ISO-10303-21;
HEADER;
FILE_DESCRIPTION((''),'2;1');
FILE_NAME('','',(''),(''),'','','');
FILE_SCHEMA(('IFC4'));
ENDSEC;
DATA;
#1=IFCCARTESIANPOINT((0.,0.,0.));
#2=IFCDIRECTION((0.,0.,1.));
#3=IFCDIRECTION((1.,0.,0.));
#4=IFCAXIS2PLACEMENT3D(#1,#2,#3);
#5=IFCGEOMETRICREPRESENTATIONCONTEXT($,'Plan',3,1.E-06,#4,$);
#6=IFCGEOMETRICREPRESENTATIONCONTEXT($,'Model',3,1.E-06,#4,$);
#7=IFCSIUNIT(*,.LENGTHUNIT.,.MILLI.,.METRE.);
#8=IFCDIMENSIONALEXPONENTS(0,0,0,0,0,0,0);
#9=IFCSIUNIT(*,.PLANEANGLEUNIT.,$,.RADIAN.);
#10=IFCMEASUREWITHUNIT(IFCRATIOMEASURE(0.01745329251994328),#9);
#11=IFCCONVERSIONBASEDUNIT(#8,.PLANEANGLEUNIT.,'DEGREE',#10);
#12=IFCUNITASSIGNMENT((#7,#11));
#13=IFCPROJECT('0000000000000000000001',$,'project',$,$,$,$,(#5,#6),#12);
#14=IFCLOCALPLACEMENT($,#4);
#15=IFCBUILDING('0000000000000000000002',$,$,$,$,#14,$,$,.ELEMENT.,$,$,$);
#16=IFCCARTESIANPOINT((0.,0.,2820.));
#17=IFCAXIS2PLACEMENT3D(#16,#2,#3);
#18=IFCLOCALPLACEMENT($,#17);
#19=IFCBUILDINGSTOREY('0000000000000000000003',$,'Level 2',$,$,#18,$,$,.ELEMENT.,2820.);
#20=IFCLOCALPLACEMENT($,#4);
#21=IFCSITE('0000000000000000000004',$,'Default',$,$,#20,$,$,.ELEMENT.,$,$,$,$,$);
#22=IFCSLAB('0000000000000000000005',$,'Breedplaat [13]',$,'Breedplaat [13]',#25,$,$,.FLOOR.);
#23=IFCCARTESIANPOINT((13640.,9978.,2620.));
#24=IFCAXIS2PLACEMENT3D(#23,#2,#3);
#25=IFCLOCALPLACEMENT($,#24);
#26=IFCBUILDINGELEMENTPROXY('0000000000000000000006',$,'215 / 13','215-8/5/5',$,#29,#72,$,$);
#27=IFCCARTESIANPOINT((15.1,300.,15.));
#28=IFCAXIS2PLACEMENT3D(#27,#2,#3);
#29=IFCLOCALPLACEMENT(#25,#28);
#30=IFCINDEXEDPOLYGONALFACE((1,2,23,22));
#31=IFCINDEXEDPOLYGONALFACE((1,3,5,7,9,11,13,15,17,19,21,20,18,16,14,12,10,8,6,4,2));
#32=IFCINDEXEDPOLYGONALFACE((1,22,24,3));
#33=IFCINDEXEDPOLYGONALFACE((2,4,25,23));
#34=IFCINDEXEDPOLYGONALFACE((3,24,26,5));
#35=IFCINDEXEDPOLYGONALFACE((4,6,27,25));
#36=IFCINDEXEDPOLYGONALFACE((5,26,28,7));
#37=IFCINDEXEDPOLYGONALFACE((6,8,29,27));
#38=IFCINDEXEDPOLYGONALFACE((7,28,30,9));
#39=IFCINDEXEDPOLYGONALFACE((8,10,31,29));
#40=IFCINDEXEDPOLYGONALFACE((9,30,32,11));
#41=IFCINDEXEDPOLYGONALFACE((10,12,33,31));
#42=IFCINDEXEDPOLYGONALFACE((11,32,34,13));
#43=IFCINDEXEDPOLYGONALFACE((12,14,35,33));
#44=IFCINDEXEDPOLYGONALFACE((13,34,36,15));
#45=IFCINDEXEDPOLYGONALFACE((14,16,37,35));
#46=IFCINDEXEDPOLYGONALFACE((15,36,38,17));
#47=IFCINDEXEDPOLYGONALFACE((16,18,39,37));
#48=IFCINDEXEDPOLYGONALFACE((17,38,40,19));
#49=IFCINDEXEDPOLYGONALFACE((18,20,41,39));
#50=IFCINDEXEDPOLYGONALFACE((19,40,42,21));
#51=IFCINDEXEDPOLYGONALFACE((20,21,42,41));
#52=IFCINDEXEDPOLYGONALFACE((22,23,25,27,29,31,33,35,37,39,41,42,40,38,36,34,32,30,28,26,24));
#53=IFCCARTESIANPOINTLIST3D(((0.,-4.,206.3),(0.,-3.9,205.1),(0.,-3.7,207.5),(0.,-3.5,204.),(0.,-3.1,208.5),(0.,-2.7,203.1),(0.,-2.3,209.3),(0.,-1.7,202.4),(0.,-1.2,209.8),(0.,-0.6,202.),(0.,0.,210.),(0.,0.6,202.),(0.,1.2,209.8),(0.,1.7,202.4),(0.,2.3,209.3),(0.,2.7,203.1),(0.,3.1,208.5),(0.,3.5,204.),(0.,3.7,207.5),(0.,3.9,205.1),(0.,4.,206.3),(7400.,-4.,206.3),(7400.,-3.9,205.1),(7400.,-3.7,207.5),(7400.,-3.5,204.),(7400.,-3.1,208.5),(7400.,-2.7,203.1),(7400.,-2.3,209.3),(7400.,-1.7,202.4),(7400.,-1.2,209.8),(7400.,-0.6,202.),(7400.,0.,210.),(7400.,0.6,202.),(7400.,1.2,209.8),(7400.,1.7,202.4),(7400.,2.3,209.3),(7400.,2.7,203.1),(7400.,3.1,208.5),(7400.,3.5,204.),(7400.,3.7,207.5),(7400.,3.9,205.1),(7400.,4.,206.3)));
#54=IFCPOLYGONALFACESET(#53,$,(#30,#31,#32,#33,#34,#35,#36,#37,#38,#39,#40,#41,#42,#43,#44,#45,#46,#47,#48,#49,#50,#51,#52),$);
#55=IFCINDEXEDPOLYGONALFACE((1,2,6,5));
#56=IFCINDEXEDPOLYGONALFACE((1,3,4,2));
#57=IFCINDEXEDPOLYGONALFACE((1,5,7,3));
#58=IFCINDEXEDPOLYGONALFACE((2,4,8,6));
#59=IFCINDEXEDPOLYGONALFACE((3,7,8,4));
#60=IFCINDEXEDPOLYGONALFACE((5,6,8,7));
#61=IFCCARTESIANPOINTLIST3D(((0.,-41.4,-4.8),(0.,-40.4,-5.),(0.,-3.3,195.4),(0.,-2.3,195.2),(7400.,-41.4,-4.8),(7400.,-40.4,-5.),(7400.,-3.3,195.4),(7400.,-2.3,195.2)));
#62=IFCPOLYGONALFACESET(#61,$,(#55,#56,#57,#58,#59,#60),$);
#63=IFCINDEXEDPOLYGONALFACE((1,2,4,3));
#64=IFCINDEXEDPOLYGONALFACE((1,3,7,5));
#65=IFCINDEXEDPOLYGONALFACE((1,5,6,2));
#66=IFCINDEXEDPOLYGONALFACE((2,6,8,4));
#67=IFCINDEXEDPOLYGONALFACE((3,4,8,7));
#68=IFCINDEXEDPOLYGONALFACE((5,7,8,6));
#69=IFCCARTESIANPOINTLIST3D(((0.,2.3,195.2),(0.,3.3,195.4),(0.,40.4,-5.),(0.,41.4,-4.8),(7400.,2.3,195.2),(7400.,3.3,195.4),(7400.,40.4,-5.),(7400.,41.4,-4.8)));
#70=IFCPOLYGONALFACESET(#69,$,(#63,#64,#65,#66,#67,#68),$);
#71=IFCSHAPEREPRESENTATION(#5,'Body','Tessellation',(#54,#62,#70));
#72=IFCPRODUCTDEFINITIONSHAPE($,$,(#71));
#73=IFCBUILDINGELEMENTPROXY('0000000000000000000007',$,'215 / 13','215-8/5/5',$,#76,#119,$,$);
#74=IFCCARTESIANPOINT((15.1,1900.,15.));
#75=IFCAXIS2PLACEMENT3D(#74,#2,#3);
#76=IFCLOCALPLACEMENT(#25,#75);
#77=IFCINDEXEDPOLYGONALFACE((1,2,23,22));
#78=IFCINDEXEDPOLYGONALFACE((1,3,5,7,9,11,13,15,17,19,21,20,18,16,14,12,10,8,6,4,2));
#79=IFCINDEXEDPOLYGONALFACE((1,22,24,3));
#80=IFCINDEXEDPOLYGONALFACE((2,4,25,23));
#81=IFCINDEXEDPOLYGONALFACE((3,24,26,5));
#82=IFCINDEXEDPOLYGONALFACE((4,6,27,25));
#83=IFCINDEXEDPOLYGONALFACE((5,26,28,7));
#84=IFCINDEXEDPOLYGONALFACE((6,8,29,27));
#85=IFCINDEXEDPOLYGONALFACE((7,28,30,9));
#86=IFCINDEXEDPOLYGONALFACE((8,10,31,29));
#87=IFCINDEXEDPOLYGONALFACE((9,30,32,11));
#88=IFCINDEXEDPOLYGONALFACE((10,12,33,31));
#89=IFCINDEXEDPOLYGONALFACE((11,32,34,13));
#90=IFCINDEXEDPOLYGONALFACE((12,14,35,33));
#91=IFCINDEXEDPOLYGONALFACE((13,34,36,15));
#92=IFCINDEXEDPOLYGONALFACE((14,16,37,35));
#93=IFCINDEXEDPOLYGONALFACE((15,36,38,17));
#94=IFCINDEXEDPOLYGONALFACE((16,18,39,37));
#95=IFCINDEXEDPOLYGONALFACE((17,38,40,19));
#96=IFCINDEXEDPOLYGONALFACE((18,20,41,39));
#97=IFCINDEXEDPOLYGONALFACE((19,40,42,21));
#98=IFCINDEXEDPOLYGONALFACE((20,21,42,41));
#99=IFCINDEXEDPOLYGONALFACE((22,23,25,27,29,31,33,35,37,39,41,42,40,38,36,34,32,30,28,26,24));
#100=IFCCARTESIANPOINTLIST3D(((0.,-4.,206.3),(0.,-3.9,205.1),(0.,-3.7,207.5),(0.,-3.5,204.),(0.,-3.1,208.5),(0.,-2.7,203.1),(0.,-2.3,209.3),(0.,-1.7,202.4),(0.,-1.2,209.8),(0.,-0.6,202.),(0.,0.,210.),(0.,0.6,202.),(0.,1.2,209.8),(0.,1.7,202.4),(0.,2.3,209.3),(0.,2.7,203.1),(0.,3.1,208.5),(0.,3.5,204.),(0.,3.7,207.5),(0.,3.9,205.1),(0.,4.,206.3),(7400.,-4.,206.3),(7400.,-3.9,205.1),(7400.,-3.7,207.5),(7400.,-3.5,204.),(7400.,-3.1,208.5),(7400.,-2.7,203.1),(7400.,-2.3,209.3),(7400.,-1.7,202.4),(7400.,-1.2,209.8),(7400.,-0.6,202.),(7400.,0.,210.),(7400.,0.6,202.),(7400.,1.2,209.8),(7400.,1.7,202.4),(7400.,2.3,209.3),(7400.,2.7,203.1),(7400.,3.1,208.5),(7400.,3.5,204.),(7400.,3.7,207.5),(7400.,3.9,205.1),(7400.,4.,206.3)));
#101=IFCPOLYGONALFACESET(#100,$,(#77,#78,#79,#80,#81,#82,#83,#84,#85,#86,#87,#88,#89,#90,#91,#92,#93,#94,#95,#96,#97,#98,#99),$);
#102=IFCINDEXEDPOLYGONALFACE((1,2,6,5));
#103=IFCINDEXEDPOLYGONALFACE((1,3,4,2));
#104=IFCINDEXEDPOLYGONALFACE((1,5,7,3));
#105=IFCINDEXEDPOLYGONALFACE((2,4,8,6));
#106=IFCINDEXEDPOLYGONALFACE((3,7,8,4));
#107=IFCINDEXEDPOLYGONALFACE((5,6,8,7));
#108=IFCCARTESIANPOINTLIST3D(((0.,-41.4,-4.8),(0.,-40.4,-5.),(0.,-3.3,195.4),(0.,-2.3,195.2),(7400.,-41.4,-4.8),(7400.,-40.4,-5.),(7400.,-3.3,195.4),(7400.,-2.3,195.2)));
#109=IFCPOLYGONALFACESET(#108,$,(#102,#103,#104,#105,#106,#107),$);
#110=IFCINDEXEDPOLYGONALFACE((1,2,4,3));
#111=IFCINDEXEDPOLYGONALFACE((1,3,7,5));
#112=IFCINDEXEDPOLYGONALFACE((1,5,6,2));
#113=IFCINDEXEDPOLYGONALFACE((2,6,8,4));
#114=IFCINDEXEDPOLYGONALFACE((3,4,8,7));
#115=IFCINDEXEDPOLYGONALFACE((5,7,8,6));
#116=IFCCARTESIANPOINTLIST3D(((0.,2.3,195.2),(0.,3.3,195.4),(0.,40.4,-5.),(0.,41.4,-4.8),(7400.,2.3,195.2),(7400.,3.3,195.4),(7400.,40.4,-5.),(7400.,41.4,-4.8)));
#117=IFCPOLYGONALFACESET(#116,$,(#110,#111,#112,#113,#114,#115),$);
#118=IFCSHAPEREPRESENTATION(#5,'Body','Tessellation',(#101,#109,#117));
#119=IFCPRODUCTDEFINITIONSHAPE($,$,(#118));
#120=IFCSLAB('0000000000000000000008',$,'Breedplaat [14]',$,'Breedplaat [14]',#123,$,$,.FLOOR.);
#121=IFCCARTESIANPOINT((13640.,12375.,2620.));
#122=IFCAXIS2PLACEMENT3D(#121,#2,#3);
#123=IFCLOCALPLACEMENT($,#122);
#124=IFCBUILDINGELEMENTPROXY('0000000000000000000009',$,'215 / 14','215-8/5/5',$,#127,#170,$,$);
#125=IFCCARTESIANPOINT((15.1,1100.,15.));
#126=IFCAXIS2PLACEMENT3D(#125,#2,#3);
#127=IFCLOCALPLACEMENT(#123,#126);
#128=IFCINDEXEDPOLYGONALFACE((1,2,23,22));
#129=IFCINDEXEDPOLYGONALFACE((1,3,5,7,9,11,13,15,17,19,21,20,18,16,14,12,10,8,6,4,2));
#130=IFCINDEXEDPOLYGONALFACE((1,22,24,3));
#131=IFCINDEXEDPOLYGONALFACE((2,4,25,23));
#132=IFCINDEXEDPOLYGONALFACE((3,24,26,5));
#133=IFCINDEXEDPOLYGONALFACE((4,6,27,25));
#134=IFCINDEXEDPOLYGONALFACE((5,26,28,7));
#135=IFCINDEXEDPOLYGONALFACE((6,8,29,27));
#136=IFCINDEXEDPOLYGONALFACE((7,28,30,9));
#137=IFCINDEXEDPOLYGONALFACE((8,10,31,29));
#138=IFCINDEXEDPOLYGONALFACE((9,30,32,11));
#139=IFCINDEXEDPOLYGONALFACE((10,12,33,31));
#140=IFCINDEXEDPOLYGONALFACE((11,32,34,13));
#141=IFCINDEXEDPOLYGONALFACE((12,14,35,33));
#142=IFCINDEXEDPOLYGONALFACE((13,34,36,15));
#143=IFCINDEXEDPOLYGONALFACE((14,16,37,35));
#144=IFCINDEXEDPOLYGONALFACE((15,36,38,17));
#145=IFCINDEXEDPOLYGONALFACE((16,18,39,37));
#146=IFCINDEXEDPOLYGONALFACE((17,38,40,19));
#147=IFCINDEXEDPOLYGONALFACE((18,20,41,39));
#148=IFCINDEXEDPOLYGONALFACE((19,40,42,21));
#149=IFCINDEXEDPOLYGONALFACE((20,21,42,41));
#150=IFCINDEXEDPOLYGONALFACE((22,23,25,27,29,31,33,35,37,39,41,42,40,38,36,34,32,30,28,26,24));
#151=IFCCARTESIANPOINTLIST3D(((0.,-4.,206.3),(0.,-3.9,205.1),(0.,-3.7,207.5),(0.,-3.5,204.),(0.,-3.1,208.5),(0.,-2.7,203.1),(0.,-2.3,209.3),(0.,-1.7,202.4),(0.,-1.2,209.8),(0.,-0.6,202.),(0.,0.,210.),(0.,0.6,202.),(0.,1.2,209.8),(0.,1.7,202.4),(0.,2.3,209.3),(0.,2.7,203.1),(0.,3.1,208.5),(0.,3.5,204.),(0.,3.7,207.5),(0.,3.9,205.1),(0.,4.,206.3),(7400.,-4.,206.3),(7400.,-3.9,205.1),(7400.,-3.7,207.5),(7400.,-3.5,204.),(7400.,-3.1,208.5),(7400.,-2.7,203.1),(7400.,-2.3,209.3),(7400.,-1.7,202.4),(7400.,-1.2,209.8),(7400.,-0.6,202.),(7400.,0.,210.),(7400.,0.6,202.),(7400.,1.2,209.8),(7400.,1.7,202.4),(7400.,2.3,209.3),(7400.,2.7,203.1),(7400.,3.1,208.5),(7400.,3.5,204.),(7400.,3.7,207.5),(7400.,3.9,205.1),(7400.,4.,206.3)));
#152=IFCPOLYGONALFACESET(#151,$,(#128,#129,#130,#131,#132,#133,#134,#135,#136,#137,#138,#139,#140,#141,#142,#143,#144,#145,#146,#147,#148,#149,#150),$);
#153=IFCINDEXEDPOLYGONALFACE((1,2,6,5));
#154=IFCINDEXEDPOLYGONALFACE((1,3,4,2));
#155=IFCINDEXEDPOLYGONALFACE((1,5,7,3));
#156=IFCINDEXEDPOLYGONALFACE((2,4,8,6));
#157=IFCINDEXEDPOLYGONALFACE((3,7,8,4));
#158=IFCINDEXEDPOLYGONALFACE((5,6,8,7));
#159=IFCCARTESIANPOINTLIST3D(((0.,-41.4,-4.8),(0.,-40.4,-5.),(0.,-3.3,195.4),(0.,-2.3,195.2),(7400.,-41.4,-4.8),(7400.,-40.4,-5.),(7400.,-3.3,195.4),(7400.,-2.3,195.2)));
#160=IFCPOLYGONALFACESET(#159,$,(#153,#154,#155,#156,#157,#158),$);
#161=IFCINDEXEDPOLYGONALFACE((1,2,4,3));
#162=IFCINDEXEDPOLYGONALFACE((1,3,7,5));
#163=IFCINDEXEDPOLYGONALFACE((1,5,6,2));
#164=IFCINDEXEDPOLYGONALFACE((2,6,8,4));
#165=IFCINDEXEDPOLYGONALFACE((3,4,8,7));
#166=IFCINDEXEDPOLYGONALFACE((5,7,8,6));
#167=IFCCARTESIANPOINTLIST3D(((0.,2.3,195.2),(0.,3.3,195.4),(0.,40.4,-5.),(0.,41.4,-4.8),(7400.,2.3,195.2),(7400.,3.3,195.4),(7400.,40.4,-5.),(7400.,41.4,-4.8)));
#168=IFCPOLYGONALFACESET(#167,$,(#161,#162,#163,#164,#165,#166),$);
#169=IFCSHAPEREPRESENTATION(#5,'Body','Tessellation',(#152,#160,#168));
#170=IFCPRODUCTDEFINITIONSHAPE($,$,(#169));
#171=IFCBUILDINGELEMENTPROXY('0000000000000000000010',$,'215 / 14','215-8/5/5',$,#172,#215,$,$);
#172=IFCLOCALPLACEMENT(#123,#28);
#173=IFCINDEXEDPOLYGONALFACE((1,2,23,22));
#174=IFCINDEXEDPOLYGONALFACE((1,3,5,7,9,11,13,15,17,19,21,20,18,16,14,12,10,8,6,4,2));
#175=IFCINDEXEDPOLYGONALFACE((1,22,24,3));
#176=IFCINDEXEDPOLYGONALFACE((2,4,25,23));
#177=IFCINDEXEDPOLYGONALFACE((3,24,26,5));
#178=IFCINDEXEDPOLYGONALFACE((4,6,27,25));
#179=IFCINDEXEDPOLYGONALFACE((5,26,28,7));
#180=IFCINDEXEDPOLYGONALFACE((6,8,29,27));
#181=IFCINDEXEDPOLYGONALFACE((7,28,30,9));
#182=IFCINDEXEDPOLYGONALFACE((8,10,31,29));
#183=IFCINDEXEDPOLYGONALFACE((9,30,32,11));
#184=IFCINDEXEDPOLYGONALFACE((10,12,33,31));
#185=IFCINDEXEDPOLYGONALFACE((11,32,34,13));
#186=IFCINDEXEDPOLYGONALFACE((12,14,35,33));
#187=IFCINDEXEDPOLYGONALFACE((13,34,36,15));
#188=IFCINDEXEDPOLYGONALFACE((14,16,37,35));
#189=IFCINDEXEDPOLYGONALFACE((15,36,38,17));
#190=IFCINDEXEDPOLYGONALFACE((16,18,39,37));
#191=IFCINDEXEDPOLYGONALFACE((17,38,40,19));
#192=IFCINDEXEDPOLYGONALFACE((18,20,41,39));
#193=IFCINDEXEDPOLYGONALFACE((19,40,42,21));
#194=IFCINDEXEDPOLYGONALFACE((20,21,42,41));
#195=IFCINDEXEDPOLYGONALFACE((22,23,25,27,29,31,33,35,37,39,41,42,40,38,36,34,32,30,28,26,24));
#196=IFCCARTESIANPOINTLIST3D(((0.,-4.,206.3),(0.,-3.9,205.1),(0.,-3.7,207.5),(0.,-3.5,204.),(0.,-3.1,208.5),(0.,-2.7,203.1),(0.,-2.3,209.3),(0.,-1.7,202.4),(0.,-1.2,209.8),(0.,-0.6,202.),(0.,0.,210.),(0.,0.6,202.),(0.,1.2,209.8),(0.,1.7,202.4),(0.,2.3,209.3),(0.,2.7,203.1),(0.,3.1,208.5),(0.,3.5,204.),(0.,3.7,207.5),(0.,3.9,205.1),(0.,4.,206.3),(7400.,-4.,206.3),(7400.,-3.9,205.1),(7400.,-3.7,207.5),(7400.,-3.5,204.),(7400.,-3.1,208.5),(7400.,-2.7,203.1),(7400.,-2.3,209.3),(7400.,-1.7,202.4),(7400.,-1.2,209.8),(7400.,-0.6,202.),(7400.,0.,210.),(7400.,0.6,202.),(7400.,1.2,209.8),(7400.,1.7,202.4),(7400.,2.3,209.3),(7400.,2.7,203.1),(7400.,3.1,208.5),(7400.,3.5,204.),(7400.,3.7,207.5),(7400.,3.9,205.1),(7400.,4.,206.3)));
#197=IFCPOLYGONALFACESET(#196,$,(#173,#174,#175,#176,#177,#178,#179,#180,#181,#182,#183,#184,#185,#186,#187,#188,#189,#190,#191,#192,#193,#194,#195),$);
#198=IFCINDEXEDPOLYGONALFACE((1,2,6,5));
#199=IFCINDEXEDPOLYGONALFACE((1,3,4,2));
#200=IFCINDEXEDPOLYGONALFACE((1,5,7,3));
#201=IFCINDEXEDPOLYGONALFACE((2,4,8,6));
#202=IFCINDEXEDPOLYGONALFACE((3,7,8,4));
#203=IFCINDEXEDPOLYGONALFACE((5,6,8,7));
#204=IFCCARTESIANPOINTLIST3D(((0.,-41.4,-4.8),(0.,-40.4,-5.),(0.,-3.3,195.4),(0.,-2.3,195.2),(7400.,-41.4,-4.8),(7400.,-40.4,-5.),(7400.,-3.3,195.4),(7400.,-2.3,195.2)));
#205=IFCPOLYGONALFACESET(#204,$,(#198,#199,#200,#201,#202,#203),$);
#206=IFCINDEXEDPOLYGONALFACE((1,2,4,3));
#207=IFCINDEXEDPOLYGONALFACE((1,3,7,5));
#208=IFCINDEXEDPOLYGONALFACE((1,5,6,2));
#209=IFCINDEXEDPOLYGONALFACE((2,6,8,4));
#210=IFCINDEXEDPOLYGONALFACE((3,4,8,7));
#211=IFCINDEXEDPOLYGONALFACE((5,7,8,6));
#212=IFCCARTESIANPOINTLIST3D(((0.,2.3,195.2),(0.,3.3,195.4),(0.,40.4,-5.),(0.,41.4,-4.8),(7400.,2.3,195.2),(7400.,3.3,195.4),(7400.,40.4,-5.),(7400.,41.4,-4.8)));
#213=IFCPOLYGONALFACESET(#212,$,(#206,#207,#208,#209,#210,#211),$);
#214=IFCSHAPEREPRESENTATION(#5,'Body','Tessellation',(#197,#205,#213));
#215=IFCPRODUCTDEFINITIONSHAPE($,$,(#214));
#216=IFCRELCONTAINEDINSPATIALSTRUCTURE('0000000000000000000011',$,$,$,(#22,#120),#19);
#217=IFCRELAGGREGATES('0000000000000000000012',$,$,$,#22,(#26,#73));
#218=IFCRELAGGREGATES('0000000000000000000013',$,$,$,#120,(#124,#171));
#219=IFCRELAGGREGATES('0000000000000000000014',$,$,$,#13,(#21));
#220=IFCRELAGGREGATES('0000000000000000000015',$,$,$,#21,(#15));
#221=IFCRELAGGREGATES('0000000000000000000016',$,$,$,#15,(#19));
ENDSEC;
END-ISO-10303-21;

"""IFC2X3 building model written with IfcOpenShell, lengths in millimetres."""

from ifc_helpers import new_model, entity, si_unit, converted_unit, frame, origin_with_axes, origin_2d_with_axis, place, context, project, spatial, rectangle, circle, extrude, element, aggregate, save


model = new_model("IFC2X3")

# Units and contexts
plan_context = context("Plan", 3, precision=1e-06, world=origin_with_axes())
model_context = context("Model", 3, precision=1e-06, world=origin_with_axes())
ifc_project = project(units=[si_unit("LENGTHUNIT", "METRE", prefix="MILLI"), converted_unit("PLANEANGLEUNIT", "DEGREE", entity("IfcRatioMeasure", 0.01745329251994328), si_unit("PLANEANGLEUNIT", "RADIAN"), dimensions=[0, 0, 0, 0, 0, 0, 0])], contexts=[plan_context, model_context])

# Site, building, storey
site_placement = place(None, origin_with_axes())
site = spatial("IfcSite", under=ifc_project, at=site_placement, Name="Default", CompositionType="ELEMENT")
building_placement = place(None, origin_with_axes())
building = spatial("IfcBuilding", under=site, at=building_placement, CompositionType="ELEMENT")
storey_placement = place(None, frame((0.0, 0.0, 2820.0), z_axis=(0.0, 0.0, 1.0), x_axis=(1.0, 0.0, 0.0)))
storey = spatial("IfcBuildingStorey", under=building, at=storey_placement, Name="Level 2", CompositionType="ELEMENT", Elevation=2820.0)

# Slabs, building element proxies
slab_1_placement = place(None, frame((13640.0, 9978.0, 2620.0), z_axis=(0.0, 0.0, 1.0), x_axis=(1.0, 0.0, 0.0)))
slab_1 = element("IfcSlab", 1, at=slab_1_placement, inside=storey, Name="Breedplaat [13]", ObjectType="Breedplaat [13]", PredefinedType="FLOOR")
proxy_1_placement = place(slab_1_placement, frame((15.1, 300.0, 15.0), z_axis=(0.0, 0.0, 1.0), x_axis=(1.0, 0.0, 0.0)))
proxy_1 = element("IfcBuildingElementProxy", 2, at=proxy_1_placement, Name="215 / 13", Description="215-8/5/5", context=plan_context, shape_type="SweptSolid", body=[
    extrude(circle(Radius=4.0, at=origin_2d_with_axis()), frame((0.0, 0.0, 206.0), z_axis=(1.0, 0.0, 0.0), x_axis=(0.0, 0.0, 1.0)), (0.0, 0.0, 1.0), 7400.0),
    extrude(rectangle(XDim=203.8, YDim=1.0, at=origin_2d_with_axis()), frame((0.0, -21.9, 95.2), z_axis=(1.0, 0.0, 0.0), x_axis=(0.0, 0.187112, 0.982339)), (0.0, 0.0, 1.0), 7400.0),
    extrude(rectangle(XDim=203.8, YDim=1.0, at=origin_2d_with_axis()), frame((0.0, 21.9, 95.2), z_axis=(1.0, 0.0, 0.0), x_axis=(0.0, -0.187112, 0.982339)), (0.0, 0.0, 1.0), 7400.0),
])
proxy_2_placement = place(slab_1_placement, frame((15.1, 1900.0, 15.0), z_axis=(0.0, 0.0, 1.0), x_axis=(1.0, 0.0, 0.0)))
proxy_2 = element("IfcBuildingElementProxy", 3, at=proxy_2_placement, Name="215 / 13", Description="215-8/5/5", context=plan_context, shape_type="SweptSolid", body=[
    extrude(circle(Radius=4.0, at=origin_2d_with_axis()), frame((0.0, 0.0, 206.0), z_axis=(1.0, 0.0, 0.0), x_axis=(0.0, 0.0, 1.0)), (0.0, 0.0, 1.0), 7400.0),
    extrude(rectangle(XDim=203.8, YDim=1.0, at=origin_2d_with_axis()), frame((0.0, -21.9, 95.2), z_axis=(1.0, 0.0, 0.0), x_axis=(0.0, 0.187112, 0.982339)), (0.0, 0.0, 1.0), 7400.0),
    extrude(rectangle(XDim=203.8, YDim=1.0, at=origin_2d_with_axis()), frame((0.0, 21.9, 95.2), z_axis=(1.0, 0.0, 0.0), x_axis=(0.0, -0.187112, 0.982339)), (0.0, 0.0, 1.0), 7400.0),
])
aggregate(slab_1, [proxy_1, proxy_2])
slab_2_placement = place(None, frame((13640.0, 12375.0, 2620.0), z_axis=(0.0, 0.0, 1.0), x_axis=(1.0, 0.0, 0.0)))
slab_2 = element("IfcSlab", 4, at=slab_2_placement, inside=storey, Name="Breedplaat [14]", ObjectType="Breedplaat [14]", PredefinedType="FLOOR")
proxy_3_placement = place(slab_2_placement, frame((15.1, 1100.0, 15.0), z_axis=(0.0, 0.0, 1.0), x_axis=(1.0, 0.0, 0.0)))
proxy_3 = element("IfcBuildingElementProxy", 5, at=proxy_3_placement, Name="215 / 14", Description="215-8/5/5", context=plan_context, shape_type="SweptSolid", body=[
    extrude(circle(Radius=4.0, at=origin_2d_with_axis()), frame((0.0, 0.0, 206.0), z_axis=(1.0, 0.0, 0.0), x_axis=(0.0, 0.0, 1.0)), (0.0, 0.0, 1.0), 7400.0),
    extrude(rectangle(XDim=203.8, YDim=1.0, at=origin_2d_with_axis()), frame((0.0, -21.9, 95.2), z_axis=(1.0, 0.0, 0.0), x_axis=(0.0, 0.187112, 0.982339)), (0.0, 0.0, 1.0), 7400.0),
    extrude(rectangle(XDim=203.8, YDim=1.0, at=origin_2d_with_axis()), frame((0.0, 21.9, 95.2), z_axis=(1.0, 0.0, 0.0), x_axis=(0.0, -0.187112, 0.982339)), (0.0, 0.0, 1.0), 7400.0),
])
proxy_4_placement = place(slab_2_placement, frame((15.1, 300.0, 15.0), z_axis=(0.0, 0.0, 1.0), x_axis=(1.0, 0.0, 0.0)))
proxy_4 = element("IfcBuildingElementProxy", 6, at=proxy_4_placement, Name="215 / 14", Description="215-8/5/5", context=plan_context, shape_type="SweptSolid", body=[
    extrude(circle(Radius=4.0, at=origin_2d_with_axis()), frame((0.0, 0.0, 206.0), z_axis=(1.0, 0.0, 0.0), x_axis=(0.0, 0.0, 1.0)), (0.0, 0.0, 1.0), 7400.0),
    extrude(rectangle(XDim=203.8, YDim=1.0, at=origin_2d_with_axis()), frame((0.0, -21.9, 95.2), z_axis=(1.0, 0.0, 0.0), x_axis=(0.0, 0.187112, 0.982339)), (0.0, 0.0, 1.0), 7400.0),
    extrude(rectangle(XDim=203.8, YDim=1.0, at=origin_2d_with_axis()), frame((0.0, 21.9, 95.2), z_axis=(1.0, 0.0, 0.0), x_axis=(0.0, -0.187112, 0.982339)), (0.0, 0.0, 1.0), 7400.0),
])
aggregate(slab_2, [proxy_3, proxy_4])

save(model, "model.ifc")
